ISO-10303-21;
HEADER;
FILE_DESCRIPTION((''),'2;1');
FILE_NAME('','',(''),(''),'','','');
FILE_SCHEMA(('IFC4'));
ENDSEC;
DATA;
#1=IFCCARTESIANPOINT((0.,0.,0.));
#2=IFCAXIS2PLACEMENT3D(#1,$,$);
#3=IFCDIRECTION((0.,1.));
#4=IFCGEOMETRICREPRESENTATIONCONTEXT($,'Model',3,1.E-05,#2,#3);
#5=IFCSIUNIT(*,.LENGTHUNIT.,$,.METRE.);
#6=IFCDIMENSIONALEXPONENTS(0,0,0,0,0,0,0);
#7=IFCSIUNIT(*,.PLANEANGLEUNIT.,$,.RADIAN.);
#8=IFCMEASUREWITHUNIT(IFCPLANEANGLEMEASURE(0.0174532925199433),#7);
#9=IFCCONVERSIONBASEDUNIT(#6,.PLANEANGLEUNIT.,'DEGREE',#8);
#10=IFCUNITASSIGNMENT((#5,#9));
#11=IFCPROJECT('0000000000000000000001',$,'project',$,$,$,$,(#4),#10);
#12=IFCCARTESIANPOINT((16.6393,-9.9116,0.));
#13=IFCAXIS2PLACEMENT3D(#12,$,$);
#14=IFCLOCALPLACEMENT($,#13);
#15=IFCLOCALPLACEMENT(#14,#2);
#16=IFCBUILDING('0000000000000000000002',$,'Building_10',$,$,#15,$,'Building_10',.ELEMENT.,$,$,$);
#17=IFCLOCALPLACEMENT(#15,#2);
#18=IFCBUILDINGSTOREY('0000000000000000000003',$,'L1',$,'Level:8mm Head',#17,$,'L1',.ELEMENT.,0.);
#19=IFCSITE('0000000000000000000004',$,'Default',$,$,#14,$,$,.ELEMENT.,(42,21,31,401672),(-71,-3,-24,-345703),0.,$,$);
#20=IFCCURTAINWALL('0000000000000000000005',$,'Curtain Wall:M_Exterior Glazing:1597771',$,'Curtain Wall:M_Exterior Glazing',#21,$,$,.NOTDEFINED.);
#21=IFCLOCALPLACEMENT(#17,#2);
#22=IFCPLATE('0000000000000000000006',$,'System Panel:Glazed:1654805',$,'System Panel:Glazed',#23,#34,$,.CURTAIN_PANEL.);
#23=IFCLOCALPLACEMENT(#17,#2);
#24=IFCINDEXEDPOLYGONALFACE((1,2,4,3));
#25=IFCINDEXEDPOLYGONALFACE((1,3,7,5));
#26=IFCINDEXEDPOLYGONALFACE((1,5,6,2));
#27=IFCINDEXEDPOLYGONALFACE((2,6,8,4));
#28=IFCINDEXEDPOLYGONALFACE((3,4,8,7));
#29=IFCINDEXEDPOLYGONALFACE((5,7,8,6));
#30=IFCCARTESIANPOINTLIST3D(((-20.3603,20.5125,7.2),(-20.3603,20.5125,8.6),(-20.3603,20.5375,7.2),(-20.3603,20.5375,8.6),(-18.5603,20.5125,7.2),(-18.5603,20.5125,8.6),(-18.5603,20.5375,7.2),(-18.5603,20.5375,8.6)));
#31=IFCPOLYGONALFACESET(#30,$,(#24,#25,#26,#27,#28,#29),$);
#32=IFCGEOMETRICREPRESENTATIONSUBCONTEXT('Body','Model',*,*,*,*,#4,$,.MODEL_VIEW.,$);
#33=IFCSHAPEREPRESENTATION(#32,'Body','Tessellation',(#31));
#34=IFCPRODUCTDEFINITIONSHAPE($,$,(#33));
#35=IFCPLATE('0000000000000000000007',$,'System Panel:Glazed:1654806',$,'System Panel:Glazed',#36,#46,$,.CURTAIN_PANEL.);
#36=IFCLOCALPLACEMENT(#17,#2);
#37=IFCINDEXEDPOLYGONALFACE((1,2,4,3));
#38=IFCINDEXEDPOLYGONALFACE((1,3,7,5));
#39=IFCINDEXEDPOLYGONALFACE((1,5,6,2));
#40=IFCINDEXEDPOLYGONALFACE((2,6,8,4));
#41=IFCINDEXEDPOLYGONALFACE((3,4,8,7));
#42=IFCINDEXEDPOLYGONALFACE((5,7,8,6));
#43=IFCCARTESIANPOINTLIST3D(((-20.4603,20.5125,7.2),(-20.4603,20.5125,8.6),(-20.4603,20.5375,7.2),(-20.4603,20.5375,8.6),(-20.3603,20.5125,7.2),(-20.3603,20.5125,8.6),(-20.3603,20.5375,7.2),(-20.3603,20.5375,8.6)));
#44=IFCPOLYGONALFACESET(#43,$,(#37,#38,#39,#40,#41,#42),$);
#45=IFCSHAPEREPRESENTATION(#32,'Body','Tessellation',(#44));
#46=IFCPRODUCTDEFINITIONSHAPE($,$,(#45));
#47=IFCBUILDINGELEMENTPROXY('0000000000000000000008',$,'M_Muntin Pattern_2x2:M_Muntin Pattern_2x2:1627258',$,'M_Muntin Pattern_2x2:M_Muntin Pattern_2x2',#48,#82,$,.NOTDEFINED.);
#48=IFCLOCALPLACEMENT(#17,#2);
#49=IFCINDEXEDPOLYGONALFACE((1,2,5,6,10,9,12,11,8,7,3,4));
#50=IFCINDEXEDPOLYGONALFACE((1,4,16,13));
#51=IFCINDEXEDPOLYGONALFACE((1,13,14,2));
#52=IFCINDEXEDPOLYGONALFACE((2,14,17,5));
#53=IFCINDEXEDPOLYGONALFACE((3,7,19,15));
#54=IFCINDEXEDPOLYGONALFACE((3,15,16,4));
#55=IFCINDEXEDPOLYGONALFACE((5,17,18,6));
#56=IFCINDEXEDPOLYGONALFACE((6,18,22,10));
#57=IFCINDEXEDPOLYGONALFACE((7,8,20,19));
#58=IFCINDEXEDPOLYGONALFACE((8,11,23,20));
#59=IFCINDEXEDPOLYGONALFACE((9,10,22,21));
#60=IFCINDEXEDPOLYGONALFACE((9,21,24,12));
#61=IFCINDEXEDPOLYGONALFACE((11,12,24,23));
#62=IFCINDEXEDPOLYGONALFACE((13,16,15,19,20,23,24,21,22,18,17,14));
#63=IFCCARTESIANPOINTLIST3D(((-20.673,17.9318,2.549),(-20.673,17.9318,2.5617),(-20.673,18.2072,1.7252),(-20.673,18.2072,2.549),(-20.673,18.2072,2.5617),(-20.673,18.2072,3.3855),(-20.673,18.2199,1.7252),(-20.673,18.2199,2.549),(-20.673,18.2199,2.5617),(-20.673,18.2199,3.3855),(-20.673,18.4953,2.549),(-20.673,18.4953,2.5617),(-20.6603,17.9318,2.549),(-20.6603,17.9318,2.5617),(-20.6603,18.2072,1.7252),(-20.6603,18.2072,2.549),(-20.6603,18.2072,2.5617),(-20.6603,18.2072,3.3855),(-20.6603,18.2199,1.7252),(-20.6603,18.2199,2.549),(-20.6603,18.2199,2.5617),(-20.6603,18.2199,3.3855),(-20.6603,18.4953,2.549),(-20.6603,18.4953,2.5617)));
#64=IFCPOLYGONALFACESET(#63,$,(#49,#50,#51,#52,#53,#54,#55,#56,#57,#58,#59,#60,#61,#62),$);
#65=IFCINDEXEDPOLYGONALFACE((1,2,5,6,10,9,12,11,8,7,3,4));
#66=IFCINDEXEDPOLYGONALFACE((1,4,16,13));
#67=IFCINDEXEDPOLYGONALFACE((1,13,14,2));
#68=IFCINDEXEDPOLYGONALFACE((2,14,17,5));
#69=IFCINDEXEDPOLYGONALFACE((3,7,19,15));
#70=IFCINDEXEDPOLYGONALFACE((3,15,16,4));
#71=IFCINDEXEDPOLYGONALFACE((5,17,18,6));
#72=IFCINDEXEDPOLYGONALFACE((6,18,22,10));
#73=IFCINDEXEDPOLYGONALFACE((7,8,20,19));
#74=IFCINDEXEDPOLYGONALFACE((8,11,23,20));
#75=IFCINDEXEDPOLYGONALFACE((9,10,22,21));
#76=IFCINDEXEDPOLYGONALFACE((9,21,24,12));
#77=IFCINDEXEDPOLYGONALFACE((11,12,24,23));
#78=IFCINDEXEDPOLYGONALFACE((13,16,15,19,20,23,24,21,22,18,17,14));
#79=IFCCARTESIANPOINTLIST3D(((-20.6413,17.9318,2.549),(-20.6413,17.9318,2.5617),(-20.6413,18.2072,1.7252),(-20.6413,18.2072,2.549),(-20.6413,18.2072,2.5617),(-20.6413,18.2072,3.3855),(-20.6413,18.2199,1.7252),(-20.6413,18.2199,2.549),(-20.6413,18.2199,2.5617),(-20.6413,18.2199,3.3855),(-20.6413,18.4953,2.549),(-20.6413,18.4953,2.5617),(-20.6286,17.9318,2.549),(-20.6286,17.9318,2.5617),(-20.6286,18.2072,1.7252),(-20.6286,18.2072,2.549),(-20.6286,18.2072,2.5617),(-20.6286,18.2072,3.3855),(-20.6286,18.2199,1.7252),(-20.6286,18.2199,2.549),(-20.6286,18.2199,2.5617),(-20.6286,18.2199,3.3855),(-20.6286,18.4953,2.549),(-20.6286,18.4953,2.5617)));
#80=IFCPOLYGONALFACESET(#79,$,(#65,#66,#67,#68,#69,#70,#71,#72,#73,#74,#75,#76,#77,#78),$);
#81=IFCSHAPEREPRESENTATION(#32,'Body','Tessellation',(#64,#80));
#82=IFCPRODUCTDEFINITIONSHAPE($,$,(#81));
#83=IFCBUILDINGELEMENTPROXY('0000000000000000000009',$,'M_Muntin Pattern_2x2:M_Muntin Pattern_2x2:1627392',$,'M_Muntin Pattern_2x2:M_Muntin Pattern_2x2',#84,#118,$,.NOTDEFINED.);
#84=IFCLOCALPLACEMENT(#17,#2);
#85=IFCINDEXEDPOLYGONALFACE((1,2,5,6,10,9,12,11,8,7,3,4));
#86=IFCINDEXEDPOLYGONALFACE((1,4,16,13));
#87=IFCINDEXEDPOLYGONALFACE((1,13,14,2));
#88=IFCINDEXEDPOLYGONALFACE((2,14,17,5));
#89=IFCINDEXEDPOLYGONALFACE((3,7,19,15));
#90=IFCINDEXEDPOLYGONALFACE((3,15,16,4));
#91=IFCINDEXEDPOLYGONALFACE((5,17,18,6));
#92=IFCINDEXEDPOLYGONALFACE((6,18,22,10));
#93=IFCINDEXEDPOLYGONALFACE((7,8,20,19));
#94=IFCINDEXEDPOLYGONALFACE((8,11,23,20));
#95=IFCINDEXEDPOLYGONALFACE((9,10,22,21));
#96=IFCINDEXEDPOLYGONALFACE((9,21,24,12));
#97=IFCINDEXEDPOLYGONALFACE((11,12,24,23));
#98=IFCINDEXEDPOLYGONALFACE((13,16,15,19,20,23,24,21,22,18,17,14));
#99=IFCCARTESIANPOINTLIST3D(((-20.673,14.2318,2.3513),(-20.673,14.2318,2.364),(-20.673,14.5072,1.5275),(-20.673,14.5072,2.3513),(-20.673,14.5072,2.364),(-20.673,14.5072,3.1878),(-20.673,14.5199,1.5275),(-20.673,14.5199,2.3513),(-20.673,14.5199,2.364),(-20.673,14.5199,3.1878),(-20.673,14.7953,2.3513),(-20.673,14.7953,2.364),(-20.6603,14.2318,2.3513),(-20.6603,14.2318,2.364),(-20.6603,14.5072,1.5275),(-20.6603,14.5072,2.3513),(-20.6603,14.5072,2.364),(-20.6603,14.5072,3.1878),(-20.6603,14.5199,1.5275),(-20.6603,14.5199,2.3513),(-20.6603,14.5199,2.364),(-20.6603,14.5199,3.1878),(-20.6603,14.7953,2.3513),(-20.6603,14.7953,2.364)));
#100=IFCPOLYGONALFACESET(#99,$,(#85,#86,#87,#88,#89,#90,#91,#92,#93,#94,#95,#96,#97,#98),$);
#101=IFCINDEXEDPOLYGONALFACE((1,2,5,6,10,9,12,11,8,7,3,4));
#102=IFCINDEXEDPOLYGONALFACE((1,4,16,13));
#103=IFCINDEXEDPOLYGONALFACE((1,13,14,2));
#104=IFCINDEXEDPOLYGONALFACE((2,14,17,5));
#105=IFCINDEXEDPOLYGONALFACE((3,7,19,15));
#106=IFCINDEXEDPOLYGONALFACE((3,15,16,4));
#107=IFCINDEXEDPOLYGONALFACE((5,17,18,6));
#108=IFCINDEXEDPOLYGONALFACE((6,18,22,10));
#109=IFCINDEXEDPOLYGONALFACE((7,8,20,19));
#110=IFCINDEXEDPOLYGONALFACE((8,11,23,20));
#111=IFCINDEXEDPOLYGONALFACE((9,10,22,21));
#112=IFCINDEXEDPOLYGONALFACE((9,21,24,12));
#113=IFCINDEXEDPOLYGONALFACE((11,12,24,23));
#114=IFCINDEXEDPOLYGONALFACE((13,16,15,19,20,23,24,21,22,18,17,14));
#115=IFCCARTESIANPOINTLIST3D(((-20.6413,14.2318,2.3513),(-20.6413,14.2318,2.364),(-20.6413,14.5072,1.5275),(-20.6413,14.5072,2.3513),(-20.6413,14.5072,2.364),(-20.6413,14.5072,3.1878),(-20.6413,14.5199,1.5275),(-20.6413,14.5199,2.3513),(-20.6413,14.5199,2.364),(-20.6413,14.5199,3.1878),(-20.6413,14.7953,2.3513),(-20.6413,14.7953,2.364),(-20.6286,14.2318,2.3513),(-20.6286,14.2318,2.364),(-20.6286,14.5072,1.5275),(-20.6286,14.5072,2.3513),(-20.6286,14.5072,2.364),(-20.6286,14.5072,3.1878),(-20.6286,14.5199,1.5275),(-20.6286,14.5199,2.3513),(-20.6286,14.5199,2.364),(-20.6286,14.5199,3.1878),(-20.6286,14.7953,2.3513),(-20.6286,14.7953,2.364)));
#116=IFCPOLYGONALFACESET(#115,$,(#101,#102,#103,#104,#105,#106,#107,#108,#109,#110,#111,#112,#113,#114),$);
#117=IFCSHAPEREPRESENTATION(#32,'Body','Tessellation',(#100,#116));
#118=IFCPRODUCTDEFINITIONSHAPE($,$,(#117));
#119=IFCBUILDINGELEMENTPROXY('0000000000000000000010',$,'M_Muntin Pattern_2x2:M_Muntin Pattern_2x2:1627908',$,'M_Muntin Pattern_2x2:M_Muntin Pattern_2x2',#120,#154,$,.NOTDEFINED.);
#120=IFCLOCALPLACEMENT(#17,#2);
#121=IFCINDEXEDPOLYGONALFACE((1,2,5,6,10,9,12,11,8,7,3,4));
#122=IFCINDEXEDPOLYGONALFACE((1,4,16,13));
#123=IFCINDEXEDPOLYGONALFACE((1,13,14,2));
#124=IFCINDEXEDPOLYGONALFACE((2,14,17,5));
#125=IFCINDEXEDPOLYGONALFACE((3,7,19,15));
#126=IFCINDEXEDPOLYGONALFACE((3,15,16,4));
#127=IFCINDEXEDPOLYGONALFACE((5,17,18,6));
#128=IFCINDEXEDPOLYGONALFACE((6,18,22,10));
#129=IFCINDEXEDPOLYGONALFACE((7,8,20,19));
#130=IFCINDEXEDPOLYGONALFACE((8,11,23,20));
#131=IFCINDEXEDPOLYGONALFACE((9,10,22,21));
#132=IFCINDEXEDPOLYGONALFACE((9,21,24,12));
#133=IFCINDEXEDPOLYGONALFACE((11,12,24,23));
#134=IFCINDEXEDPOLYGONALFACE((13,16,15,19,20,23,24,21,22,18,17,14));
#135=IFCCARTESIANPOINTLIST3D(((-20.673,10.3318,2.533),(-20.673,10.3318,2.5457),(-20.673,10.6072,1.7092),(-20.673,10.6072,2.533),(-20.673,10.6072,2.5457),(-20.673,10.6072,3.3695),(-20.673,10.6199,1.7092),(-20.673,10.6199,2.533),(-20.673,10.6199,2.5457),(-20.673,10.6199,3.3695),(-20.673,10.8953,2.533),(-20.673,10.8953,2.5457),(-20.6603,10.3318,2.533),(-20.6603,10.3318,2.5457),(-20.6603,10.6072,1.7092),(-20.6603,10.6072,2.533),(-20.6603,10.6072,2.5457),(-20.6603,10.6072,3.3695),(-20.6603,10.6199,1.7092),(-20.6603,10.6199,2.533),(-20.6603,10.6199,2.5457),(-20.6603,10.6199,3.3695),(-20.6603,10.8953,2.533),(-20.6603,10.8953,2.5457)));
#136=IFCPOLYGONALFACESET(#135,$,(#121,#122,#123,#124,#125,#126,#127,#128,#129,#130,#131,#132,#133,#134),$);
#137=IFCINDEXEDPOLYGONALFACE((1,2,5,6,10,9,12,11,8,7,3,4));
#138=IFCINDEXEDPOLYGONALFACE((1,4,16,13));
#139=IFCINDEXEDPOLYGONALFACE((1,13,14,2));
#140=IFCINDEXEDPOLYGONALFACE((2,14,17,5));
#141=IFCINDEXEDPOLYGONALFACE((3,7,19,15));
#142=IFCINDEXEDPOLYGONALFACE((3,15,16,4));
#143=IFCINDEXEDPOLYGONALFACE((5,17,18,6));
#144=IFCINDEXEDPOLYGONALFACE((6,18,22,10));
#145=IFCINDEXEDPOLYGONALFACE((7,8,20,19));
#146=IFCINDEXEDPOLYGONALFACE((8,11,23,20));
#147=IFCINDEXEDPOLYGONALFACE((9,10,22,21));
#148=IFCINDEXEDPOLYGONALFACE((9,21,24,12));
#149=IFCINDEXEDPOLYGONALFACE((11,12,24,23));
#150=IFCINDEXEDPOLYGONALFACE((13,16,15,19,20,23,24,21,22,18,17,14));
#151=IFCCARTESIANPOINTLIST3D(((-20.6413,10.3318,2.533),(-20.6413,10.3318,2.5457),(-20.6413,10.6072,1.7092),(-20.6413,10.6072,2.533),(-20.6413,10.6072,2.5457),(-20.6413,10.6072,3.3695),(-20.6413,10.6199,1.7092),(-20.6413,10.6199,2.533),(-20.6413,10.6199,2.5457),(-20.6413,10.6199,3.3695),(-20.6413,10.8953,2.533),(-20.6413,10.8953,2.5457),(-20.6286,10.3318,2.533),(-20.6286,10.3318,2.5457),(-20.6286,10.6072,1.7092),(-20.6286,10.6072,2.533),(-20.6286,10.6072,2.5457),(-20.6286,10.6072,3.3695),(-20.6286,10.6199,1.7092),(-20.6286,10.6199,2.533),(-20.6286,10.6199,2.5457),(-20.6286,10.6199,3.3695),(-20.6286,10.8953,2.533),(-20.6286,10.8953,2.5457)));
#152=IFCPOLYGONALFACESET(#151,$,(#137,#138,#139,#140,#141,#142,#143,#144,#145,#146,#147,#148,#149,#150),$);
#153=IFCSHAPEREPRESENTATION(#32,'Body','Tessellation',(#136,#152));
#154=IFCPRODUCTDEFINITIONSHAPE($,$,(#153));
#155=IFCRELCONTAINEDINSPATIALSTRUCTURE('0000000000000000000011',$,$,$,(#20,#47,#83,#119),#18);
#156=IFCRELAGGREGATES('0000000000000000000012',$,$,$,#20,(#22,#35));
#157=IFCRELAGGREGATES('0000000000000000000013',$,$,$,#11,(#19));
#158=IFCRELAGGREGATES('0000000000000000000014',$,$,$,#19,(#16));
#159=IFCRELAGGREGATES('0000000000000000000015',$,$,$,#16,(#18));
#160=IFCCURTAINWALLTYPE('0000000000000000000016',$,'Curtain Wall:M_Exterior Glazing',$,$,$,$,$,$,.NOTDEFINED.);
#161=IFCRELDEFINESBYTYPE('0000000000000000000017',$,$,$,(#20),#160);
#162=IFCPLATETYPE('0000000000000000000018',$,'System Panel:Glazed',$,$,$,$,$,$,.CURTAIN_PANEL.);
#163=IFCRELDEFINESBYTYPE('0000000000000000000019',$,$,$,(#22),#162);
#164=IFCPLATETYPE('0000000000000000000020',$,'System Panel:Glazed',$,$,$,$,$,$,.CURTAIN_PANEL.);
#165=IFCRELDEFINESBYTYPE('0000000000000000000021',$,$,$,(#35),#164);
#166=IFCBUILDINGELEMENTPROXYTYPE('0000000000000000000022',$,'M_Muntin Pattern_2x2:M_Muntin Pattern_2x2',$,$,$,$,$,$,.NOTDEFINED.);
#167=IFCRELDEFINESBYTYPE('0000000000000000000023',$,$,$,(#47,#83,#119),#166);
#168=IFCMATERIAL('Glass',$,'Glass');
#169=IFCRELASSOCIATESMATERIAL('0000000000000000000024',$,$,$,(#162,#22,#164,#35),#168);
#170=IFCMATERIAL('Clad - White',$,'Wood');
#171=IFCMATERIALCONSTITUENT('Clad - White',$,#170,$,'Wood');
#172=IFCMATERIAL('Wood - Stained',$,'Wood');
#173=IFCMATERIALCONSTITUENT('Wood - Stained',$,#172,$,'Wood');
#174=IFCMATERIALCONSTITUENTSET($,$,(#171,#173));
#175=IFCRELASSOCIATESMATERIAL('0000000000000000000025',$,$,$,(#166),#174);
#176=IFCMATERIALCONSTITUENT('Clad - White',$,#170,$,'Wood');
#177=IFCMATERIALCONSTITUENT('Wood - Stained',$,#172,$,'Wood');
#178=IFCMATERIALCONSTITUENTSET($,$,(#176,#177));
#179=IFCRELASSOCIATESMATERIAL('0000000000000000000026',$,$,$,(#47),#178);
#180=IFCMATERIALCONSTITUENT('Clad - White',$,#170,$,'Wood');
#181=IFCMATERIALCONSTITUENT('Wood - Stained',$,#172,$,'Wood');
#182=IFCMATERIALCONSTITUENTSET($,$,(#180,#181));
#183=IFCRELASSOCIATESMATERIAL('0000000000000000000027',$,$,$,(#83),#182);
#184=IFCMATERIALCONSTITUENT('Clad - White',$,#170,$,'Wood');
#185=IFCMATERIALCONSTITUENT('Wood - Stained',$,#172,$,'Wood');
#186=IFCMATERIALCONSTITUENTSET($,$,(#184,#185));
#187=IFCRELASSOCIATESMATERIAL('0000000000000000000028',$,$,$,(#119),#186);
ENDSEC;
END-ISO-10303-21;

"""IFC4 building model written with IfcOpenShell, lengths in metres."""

from ifc_helpers import new_model, entity, si_unit, converted_unit, direction, frame, origin, place, context, subcontext, project, spatial, indexed_curve, outline, extrude, source, transform, mapped, material, constituent, constituent_set, type_object, type_shapes, element, aggregate, save


model = new_model("IFC4")

# Units and contexts
model_context = context("Model", 3, precision=1e-05, world=origin(), true_north=direction((0.0, 1.0)))
body_context = subcontext(model_context, "Body", "Model", "MODEL_VIEW")
ifc_project = project(units=[si_unit("LENGTHUNIT", "METRE"), converted_unit("PLANEANGLEUNIT", "DEGREE", entity("IfcPlaneAngleMeasure", 0.0174532925199433), si_unit("PLANEANGLEUNIT", "RADIAN"), dimensions=[0, 0, 0, 0, 0, 0, 0])], contexts=[model_context])

# Site, building, storey
site_placement = place(None, frame((16.6393, -9.9116, 0.0)))
site = spatial("IfcSite", under=ifc_project, at=site_placement, Name="Default", CompositionType="ELEMENT", RefLatitude=(42, 21, 31, 401672), RefLongitude=(-71, -3, -24, -345703), RefElevation=0.0)
building_placement = place(site_placement, origin())
building = spatial("IfcBuilding", under=site, at=building_placement, Name="Building_10", LongName="Building_10", CompositionType="ELEMENT")
storey_placement = place(building_placement, origin())
storey = spatial("IfcBuildingStorey", under=building, at=storey_placement, Name="L1", ObjectType="Level:8mm Head", LongName="L1", CompositionType="ELEMENT", Elevation=0.0)

# Curtain wall, plates
curtain_wall_type = type_object("IfcCurtainWallType", Name="Curtain Wall:M_Exterior Glazing", PredefinedType="NOTDEFINED")
curtain_wall_placement = place(storey_placement, origin())
curtain_wall = element("IfcCurtainWall", 1, at=curtain_wall_placement, inside=storey, type_object=curtain_wall_type, Name="Curtain Wall:M_Exterior Glazing:1597771", ObjectType="Curtain Wall:M_Exterior Glazing", PredefinedType="NOTDEFINED")
ifc_material_1 = material(Name="Glass", Category="Glass")
plate_type_1 = type_object("IfcPlateType", Name="System Panel:Glazed", PredefinedType="CURTAIN_PANEL", material=ifc_material_1)
shared_shape_1 = source(origin(), body_context, "Body", "SweptSolid", [
    extrude(outline(indexed_curve([(-0.0125, -0.9), (0.0125, -0.9), (0.0125, 0.9), (-0.0125, 0.9), (-0.0125, -0.9)], self_intersect=False)), frame((0.0, 0.037, 0.0), z_axis=(0.0, 0.0, 1.0), x_axis=(0.0, 1.0, 0.0)), (0.0, 0.0, 1.0), 1.4),
])
type_shapes(plate_type_1, [shared_shape_1])
plate_1_placement = place(curtain_wall_placement, frame((-19.4603, 20.562, 7.2), z_axis=(0.0, 0.0, 1.0), x_axis=(-1.0, 0.0, 0.0)))
plate_1 = element("IfcPlate", 2, at=plate_1_placement, type_object=plate_type_1, material=ifc_material_1, Name="System Panel:Glazed:1654805", ObjectType="System Panel:Glazed", PredefinedType="CURTAIN_PANEL", context=body_context, shape_type="MappedRepresentation", body=[
    mapped(shared_shape_1, transform((0.0, 0.0, 0.0), scale=1.0)),
])
plate_type_2 = type_object("IfcPlateType", Name="System Panel:Glazed", PredefinedType="CURTAIN_PANEL", material=ifc_material_1)
shared_shape_2 = source(origin(), body_context, "Body", "SweptSolid", [
    extrude(outline(indexed_curve([(-0.0125, -0.05), (0.0125, -0.05), (0.0125, 0.05), (-0.0125, 0.05), (-0.0125, -0.05)], self_intersect=False)), frame((0.0, 0.037, 0.0), z_axis=(0.0, 0.0, 1.0), x_axis=(0.0, 1.0, 0.0)), (0.0, 0.0, 1.0), 1.4),
])
type_shapes(plate_type_2, [shared_shape_2])
plate_2_placement = place(curtain_wall_placement, frame((-20.4103, 20.562, 7.2), z_axis=(0.0, 0.0, 1.0), x_axis=(-1.0, 0.0, 0.0)))
plate_2 = element("IfcPlate", 3, at=plate_2_placement, type_object=plate_type_2, material=ifc_material_1, Name="System Panel:Glazed:1654806", ObjectType="System Panel:Glazed", PredefinedType="CURTAIN_PANEL", context=body_context, shape_type="MappedRepresentation", body=[
    mapped(shared_shape_2, transform((0.0, 0.0, 0.0), scale=1.0)),
])
aggregate(curtain_wall, [plate_1, plate_2])

# Building element proxies
ifc_material_2 = material(Name="Clad - White", Category="Wood")
ifc_constituent_1 = constituent(ifc_material_2, Name="Clad - White", Category="Wood")
ifc_material_3 = material(Name="Wood - Stained", Category="Wood")
ifc_constituent_2 = constituent(ifc_material_3, Name="Wood - Stained", Category="Wood")
ifc_constituent_set_1 = constituent_set(constituents=[ifc_constituent_1, ifc_constituent_2])
ifc_constituent_3 = constituent(ifc_material_2, Name="Clad - White", Category="Wood")
ifc_constituent_4 = constituent(ifc_material_3, Name="Wood - Stained", Category="Wood")
ifc_constituent_set_2 = constituent_set(constituents=[ifc_constituent_3, ifc_constituent_4])
building_element_proxy_type_1 = type_object("IfcBuildingElementProxyType", Name="M_Muntin Pattern_2x2:M_Muntin Pattern_2x2", PredefinedType="NOTDEFINED", material=ifc_constituent_set_2)
shared_shape_3 = source(origin(), body_context, "Body", "SweptSolid", [
    extrude(outline(indexed_curve([(0.0064, -0.0064), (0.8301, -0.0064), (0.8301, 0.0063), (0.0064, 0.0063), (0.0064, 0.2817), (-0.0063, 0.2817), (-0.0063, 0.0063), (-0.8302, 0.0063), (-0.8302, -0.0064), (-0.0063, -0.0064), (-0.0063, -0.2817), (0.0064, -0.2817), (0.0064, -0.0064)], self_intersect=False)), frame((0.0, 0.0095, 0.8301), z_axis=(0.0, 1.0, 0.0), x_axis=(0.0, 0.0, 1.0)), (0.0, 0.0, 1.0), 0.0127),
    extrude(outline(indexed_curve([(0.0064, -0.0064), (0.8302, -0.0064), (0.8302, 0.0063), (0.0064, 0.0063), (0.0064, 0.2817), (-0.0063, 0.2817), (-0.0063, 0.0063), (-0.8302, 0.0063), (-0.8302, -0.0064), (-0.0063, -0.0064), (-0.0063, -0.2817), (0.0064, -0.2817), (0.0064, -0.0064)], self_intersect=False)), frame((0.0, -0.0222, 0.8302), z_axis=(0.0, 1.0, 0.0), x_axis=(0.0, 0.0, 1.0)), (0.0, 0.0, 1.0), 0.0127),
])
type_shapes(building_element_proxy_type_1, [shared_shape_3])
proxy_1_placement = place(storey_placement, frame((-20.6508, 18.2136, 1.7252), z_axis=(0.0, 0.0, 1.0), x_axis=(0.0, 1.0, 0.0)))
element("IfcBuildingElementProxy", 4, at=proxy_1_placement, inside=storey, type_object=building_element_proxy_type_1, material=ifc_constituent_set_1, Name="M_Muntin Pattern_2x2:M_Muntin Pattern_2x2:1627258", ObjectType="M_Muntin Pattern_2x2:M_Muntin Pattern_2x2", PredefinedType="NOTDEFINED", context=body_context, shape_type="MappedRepresentation", body=[
    mapped(shared_shape_3, transform((0.0, 0.0, 0.0), scale=1.0)),
])
ifc_constituent_5 = constituent(ifc_material_2, Name="Clad - White", Category="Wood")
ifc_constituent_6 = constituent(ifc_material_3, Name="Wood - Stained", Category="Wood")
ifc_constituent_set_3 = constituent_set(constituents=[ifc_constituent_5, ifc_constituent_6])
proxy_2_placement = place(storey_placement, frame((-20.6508, 14.5136, 1.5275), z_axis=(0.0, 0.0, 1.0), x_axis=(0.0, 1.0, 0.0)))
element("IfcBuildingElementProxy", 5, at=proxy_2_placement, inside=storey, type_object=building_element_proxy_type_1, material=ifc_constituent_set_3, Name="M_Muntin Pattern_2x2:M_Muntin Pattern_2x2:1627392", ObjectType="M_Muntin Pattern_2x2:M_Muntin Pattern_2x2", PredefinedType="NOTDEFINED", context=body_context, shape_type="MappedRepresentation", body=[
    mapped(shared_shape_3, transform((0.0, 0.0, 0.0), scale=1.0)),
])
ifc_constituent_7 = constituent(ifc_material_2, Name="Clad - White", Category="Wood")
ifc_constituent_8 = constituent(ifc_material_3, Name="Wood - Stained", Category="Wood")
ifc_constituent_set_4 = constituent_set(constituents=[ifc_constituent_7, ifc_constituent_8])
proxy_3_placement = place(storey_placement, frame((-20.6508, 10.6136, 1.7092), z_axis=(0.0, 0.0, 1.0), x_axis=(0.0, 1.0, 0.0)))
element("IfcBuildingElementProxy", 6, at=proxy_3_placement, inside=storey, type_object=building_element_proxy_type_1, material=ifc_constituent_set_4, Name="M_Muntin Pattern_2x2:M_Muntin Pattern_2x2:1627908", ObjectType="M_Muntin Pattern_2x2:M_Muntin Pattern_2x2", PredefinedType="NOTDEFINED", context=body_context, shape_type="MappedRepresentation", body=[
    mapped(shared_shape_3, transform((0.0, 0.0, 0.0), scale=1.0)),
])

save(model, "model.ifc")
